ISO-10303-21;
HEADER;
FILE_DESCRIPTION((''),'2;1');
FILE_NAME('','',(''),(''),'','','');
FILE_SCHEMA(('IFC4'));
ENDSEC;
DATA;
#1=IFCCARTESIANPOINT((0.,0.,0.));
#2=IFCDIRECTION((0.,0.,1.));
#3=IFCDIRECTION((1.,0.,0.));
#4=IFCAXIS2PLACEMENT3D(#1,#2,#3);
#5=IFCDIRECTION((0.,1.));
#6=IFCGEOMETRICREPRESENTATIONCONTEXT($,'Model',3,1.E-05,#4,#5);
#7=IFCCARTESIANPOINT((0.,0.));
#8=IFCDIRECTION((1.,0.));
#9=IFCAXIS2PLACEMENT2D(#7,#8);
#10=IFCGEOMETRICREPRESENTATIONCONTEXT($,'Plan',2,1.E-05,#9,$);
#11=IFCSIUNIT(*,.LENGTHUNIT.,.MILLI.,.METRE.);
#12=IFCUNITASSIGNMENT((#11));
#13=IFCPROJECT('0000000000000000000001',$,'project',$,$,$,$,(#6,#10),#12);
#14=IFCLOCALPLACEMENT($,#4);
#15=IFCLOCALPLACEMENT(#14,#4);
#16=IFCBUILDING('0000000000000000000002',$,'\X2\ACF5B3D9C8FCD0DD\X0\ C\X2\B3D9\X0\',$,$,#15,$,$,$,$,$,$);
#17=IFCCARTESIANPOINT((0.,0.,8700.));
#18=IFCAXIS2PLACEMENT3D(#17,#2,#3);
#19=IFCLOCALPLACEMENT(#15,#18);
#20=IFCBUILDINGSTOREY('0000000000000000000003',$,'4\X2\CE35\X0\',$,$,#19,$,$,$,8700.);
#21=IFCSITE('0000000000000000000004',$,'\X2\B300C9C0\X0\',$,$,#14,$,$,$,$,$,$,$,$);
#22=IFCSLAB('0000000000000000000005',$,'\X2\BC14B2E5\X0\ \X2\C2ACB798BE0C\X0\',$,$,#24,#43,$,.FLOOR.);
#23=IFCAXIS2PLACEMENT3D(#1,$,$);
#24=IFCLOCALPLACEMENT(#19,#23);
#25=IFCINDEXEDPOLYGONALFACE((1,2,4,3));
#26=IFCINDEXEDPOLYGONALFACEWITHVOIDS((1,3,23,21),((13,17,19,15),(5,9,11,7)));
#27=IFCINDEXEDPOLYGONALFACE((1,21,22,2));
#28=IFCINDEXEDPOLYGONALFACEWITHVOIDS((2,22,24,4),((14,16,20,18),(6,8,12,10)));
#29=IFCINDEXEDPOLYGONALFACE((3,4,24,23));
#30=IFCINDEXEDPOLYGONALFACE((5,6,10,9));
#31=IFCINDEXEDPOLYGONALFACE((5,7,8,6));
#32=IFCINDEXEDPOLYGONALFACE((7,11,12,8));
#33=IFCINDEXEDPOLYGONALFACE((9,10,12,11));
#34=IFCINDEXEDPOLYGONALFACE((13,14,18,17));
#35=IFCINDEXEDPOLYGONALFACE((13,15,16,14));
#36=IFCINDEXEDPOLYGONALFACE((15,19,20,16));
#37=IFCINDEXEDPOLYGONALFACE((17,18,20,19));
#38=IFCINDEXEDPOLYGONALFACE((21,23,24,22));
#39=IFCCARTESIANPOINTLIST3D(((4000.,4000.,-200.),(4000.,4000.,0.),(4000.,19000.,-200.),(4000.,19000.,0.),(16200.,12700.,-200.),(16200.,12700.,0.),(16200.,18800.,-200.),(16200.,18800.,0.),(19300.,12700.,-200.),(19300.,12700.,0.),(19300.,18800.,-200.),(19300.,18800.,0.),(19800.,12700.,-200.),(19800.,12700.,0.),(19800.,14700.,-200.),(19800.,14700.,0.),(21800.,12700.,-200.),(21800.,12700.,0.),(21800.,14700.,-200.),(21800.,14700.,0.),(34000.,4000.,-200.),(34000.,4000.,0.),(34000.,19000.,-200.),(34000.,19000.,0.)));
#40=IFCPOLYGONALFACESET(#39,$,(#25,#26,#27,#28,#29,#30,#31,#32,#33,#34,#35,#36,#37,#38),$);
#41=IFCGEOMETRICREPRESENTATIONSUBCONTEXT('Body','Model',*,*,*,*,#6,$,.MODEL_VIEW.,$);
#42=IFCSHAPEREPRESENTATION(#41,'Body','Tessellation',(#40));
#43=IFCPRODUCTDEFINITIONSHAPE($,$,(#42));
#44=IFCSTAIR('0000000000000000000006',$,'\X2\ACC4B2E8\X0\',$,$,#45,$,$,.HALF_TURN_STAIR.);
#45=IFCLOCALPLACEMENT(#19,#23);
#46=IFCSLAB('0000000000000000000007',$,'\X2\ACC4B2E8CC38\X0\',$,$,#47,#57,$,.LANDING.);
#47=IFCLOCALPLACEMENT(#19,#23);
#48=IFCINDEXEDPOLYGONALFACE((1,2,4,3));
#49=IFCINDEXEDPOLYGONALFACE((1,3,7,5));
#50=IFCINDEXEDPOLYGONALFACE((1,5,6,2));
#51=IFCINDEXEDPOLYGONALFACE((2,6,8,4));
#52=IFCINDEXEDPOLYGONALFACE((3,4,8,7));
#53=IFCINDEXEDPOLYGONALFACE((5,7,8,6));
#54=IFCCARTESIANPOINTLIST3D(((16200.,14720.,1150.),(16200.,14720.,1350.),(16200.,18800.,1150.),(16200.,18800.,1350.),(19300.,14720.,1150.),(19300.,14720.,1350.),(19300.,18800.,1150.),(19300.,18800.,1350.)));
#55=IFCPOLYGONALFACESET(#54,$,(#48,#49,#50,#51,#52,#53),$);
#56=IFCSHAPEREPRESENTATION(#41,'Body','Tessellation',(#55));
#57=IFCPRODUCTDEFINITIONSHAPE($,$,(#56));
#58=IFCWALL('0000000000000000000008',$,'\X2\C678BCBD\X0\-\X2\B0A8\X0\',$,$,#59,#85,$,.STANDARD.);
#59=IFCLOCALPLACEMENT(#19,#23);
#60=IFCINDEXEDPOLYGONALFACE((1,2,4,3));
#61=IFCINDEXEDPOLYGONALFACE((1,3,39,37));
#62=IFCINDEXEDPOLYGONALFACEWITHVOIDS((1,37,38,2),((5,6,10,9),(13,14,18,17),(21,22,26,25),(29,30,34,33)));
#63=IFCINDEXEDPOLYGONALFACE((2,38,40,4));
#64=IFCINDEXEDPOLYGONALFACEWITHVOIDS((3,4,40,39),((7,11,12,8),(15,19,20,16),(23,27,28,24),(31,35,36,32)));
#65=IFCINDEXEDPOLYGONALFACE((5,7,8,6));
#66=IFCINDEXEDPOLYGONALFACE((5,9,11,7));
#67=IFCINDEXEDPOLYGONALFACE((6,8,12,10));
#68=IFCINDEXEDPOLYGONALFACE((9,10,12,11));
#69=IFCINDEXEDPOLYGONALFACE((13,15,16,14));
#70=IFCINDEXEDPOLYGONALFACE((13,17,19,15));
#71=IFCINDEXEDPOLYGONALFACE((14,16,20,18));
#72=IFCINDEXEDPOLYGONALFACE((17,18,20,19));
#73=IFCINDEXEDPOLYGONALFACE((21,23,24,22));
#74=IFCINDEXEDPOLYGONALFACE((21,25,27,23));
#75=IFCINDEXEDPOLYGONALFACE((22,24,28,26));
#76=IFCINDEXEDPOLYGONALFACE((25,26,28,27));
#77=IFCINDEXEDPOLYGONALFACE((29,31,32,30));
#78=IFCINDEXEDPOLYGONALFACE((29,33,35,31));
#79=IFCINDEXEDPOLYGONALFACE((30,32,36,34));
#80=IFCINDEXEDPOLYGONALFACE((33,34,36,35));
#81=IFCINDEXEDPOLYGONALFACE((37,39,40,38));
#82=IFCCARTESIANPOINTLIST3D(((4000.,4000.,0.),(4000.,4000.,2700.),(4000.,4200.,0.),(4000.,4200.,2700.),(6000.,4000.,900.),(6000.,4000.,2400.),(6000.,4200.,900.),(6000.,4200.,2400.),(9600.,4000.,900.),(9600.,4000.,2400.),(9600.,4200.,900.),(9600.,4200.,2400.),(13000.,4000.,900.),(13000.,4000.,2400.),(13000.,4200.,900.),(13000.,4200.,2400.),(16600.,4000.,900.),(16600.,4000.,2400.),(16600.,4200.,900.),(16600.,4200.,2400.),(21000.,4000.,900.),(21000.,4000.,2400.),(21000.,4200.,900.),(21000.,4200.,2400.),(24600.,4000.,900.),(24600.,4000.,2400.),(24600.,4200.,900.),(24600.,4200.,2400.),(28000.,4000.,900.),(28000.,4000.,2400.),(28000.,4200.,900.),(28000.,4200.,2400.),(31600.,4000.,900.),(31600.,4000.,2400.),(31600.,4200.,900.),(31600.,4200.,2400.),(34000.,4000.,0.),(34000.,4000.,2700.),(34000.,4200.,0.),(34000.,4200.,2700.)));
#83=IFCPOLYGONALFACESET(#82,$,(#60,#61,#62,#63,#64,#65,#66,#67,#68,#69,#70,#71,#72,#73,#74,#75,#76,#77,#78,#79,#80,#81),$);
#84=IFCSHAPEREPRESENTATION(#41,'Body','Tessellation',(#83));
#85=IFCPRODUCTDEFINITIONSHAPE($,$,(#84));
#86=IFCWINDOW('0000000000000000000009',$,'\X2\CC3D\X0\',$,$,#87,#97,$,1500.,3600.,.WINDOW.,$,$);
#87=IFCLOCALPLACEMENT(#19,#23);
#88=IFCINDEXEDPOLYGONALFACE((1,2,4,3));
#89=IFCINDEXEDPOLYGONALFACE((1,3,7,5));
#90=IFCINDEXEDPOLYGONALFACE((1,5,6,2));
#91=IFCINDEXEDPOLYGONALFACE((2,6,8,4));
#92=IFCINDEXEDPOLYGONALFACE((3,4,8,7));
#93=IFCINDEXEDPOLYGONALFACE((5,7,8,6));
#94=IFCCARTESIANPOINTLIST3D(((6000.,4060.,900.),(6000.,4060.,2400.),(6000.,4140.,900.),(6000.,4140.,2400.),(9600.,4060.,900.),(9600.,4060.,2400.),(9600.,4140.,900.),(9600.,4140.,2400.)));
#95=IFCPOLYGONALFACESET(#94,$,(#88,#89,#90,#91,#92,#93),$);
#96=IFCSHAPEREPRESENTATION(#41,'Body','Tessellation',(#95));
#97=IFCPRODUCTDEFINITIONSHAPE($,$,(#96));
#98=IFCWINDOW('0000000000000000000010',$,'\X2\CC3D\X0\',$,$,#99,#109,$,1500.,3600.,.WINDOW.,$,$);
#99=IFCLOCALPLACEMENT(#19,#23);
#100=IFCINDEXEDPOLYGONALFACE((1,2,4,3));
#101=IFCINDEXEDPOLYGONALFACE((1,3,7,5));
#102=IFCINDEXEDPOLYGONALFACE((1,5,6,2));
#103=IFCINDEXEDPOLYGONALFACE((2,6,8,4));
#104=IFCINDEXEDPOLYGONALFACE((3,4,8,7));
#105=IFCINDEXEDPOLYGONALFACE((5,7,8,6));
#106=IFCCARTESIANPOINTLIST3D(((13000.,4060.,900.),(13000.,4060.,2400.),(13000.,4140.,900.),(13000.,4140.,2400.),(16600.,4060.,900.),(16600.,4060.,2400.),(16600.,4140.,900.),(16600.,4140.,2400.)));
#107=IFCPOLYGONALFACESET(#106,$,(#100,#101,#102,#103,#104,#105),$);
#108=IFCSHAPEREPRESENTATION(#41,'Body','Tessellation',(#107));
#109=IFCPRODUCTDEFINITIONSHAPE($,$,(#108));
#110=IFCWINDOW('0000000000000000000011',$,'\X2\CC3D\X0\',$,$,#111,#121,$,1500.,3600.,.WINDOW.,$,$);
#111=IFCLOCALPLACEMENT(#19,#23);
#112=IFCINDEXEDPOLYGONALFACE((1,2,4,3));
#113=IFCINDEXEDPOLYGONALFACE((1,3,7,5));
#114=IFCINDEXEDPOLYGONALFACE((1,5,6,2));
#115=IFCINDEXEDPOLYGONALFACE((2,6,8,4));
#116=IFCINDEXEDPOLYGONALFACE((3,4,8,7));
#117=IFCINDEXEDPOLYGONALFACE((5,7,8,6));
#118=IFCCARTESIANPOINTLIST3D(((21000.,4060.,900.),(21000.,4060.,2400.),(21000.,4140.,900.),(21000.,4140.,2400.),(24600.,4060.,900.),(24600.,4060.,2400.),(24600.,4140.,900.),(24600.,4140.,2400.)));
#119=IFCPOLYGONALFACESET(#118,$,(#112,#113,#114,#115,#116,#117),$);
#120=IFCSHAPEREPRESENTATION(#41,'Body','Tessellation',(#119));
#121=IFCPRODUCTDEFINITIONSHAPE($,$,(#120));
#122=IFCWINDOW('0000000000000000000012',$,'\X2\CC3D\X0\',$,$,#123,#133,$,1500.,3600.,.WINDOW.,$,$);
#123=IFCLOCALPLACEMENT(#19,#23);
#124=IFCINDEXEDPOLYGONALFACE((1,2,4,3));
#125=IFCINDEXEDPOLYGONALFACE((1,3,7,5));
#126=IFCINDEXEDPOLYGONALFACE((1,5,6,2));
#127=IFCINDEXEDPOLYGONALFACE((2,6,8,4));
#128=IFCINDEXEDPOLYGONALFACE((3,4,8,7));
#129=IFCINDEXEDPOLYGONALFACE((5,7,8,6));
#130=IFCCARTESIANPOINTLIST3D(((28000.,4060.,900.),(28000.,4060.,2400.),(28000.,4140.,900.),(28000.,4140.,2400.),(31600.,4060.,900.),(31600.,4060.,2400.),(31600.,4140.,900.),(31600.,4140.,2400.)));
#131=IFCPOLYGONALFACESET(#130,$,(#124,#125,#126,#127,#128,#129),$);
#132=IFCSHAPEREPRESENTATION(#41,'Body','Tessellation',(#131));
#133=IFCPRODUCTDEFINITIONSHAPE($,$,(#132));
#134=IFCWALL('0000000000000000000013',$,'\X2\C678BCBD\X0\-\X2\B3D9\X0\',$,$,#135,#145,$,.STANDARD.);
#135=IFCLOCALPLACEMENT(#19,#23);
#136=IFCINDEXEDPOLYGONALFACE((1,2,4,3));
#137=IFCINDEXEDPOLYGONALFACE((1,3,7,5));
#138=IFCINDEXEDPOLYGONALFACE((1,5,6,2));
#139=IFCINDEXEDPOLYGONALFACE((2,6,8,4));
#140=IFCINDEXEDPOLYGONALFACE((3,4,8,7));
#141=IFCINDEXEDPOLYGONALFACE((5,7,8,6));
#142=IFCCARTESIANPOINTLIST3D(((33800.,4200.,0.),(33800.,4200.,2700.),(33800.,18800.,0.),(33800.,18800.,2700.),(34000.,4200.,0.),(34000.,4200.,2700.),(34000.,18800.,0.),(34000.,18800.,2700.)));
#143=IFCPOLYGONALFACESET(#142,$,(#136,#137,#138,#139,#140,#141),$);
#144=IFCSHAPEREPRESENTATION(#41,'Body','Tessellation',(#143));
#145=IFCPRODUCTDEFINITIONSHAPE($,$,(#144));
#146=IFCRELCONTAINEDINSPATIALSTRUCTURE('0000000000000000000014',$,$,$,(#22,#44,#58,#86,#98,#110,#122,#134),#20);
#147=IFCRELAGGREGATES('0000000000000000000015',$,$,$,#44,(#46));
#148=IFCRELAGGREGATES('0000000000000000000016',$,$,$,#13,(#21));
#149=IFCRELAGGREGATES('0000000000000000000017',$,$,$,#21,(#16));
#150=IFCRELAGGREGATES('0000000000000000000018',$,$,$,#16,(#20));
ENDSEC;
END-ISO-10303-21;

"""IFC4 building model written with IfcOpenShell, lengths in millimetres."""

from ifc_helpers import new_model, si_unit, direction, frame, origin_with_axes, origin_2d_with_axis, place, context, subcontext, project, spatial, polyline, outline, extrude, element, fill, aggregate, save


model = new_model("IFC4")

# Units and contexts
model_context = context("Model", 3, precision=1e-05, world=origin_with_axes(), true_north=direction((0.0, 1.0)))
plan_context = context("Plan", 2, precision=1e-05, world=origin_2d_with_axis())
body_context = subcontext(model_context, "Body", "Model", "MODEL_VIEW")
ifc_project = project(units=[si_unit("LENGTHUNIT", "METRE", prefix="MILLI")], contexts=[model_context, plan_context])

# Site, building, storey
site_placement = place(None, origin_with_axes())
site = spatial("IfcSite", under=ifc_project, at=site_placement, Name="대지")
building_placement = place(site_placement, origin_with_axes())
building = spatial("IfcBuilding", under=site, at=building_placement, Name="공동주택 C동")
storey_placement = place(building_placement, frame((0.0, 0.0, 8700.0), z_axis=(0.0, 0.0, 1.0), x_axis=(1.0, 0.0, 0.0)))
storey = spatial("IfcBuildingStorey", under=building, at=storey_placement, Name="4층", Elevation=8700.0)

# Slab
slab_1_placement = place(storey_placement, origin_with_axes())
element("IfcSlab", 1, at=slab_1_placement, inside=storey, Name="바닥 슬래브", PredefinedType="FLOOR", context=body_context, shape_type="SweptSolid", body=[
    extrude(outline(polyline([(4000.0, 4000.0), (34000.0, 4000.0), (34000.0, 19000.0), (4000.0, 19000.0), (4000.0, 4000.0)]), holes=[polyline([(16200.0, 12700.0), (19300.0, 12700.0), (19300.0, 18800.0), (16200.0, 18800.0), (16200.0, 12700.0)]), polyline([(19800.0, 12700.0), (21800.0, 12700.0), (21800.0, 14700.0), (19800.0, 14700.0), (19800.0, 12700.0)])]), frame((0.0, 0.0, -200.0), z_axis=(0.0, 0.0, 1.0), x_axis=(1.0, 0.0, 0.0)), (0.0, 0.0, 1.0), 200.0),
])

# Stair, slab
stair_placement = place(storey_placement, origin_with_axes())
stair = element("IfcStair", 2, at=stair_placement, inside=storey, Name="계단", PredefinedType="HALF_TURN_STAIR")
slab_2_placement = place(stair_placement, origin_with_axes())
slab_2 = element("IfcSlab", 3, at=slab_2_placement, Name="계단참", PredefinedType="LANDING", context=body_context, shape_type="SweptSolid", body=[
    extrude(outline(polyline([(16200.0, 14720.0), (19300.0, 14720.0), (19300.0, 18800.0), (16200.0, 18800.0), (16200.0, 14720.0)])), frame((0.0, 0.0, 1150.0), z_axis=(0.0, 0.0, 1.0), x_axis=(1.0, 0.0, 0.0)), (0.0, 0.0, 1.0), 200.0),
])

# Wall, openings, windows
wall_1_placement = place(storey_placement, origin_with_axes())
wall_1 = element("IfcWall", 4, at=wall_1_placement, inside=storey, Name="외벽-남", PredefinedType="STANDARD", context=body_context, shape_type="SweptSolid", body=[
    extrude(outline(polyline([(4000.0, 4200.0), (34000.0, 4200.0), (34000.0, 4000.0), (4000.0, 4000.0), (4000.0, 4200.0)])), origin_with_axes(), (0.0, 0.0, 1.0), 2700.0),
])
opening_1_placement = place(storey_placement, origin_with_axes())
opening_1 = element("IfcOpeningElement", 5, at=opening_1_placement, cuts=wall_1, PredefinedType="OPENING", context=body_context, shape_type="SweptSolid", body=[
    extrude(outline(polyline([(6000.0, 3950.0), (9600.0, 3950.0), (9600.0, 4250.0), (6000.0, 4250.0), (6000.0, 3950.0)])), frame((0.0, 0.0, 900.0), z_axis=(0.0, 0.0, 1.0), x_axis=(1.0, 0.0, 0.0)), (0.0, 0.0, 1.0), 1500.0),
])
opening_2_placement = place(storey_placement, origin_with_axes())
opening_2 = element("IfcOpeningElement", 6, at=opening_2_placement, cuts=wall_1, PredefinedType="OPENING", context=body_context, shape_type="SweptSolid", body=[
    extrude(outline(polyline([(13000.0, 3950.0), (16600.0, 3950.0), (16600.0, 4250.0), (13000.0, 4250.0), (13000.0, 3950.0)])), frame((0.0, 0.0, 900.0), z_axis=(0.0, 0.0, 1.0), x_axis=(1.0, 0.0, 0.0)), (0.0, 0.0, 1.0), 1500.0),
])
opening_3_placement = place(storey_placement, origin_with_axes())
opening_3 = element("IfcOpeningElement", 7, at=opening_3_placement, cuts=wall_1, PredefinedType="OPENING", context=body_context, shape_type="SweptSolid", body=[
    extrude(outline(polyline([(21000.0, 3950.0), (24600.0, 3950.0), (24600.0, 4250.0), (21000.0, 4250.0), (21000.0, 3950.0)])), frame((0.0, 0.0, 900.0), z_axis=(0.0, 0.0, 1.0), x_axis=(1.0, 0.0, 0.0)), (0.0, 0.0, 1.0), 1500.0),
])
opening_4_placement = place(storey_placement, origin_with_axes())
opening_4 = element("IfcOpeningElement", 8, at=opening_4_placement, cuts=wall_1, PredefinedType="OPENING", context=body_context, shape_type="SweptSolid", body=[
    extrude(outline(polyline([(28000.0, 3950.0), (31600.0, 3950.0), (31600.0, 4250.0), (28000.0, 4250.0), (28000.0, 3950.0)])), frame((0.0, 0.0, 900.0), z_axis=(0.0, 0.0, 1.0), x_axis=(1.0, 0.0, 0.0)), (0.0, 0.0, 1.0), 1500.0),
])
window_1_placement = place(storey_placement, origin_with_axes())
window_1 = element("IfcWindow", 9, at=window_1_placement, inside=storey, Name="창", OverallHeight=1500.0, OverallWidth=3600.0, PredefinedType="WINDOW", context=body_context, shape_type="SweptSolid", body=[
    extrude(outline(polyline([(6000.0, 4060.0), (9600.0, 4060.0), (9600.0, 4140.0), (6000.0, 4140.0), (6000.0, 4060.0)])), frame((0.0, 0.0, 900.0), z_axis=(0.0, 0.0, 1.0), x_axis=(1.0, 0.0, 0.0)), (0.0, 0.0, 1.0), 1500.0),
])
fill(opening_1, window_1)
window_2_placement = place(storey_placement, origin_with_axes())
window_2 = element("IfcWindow", 10, at=window_2_placement, inside=storey, Name="창", OverallHeight=1500.0, OverallWidth=3600.0, PredefinedType="WINDOW", context=body_context, shape_type="SweptSolid", body=[
    extrude(outline(polyline([(13000.0, 4060.0), (16600.0, 4060.0), (16600.0, 4140.0), (13000.0, 4140.0), (13000.0, 4060.0)])), frame((0.0, 0.0, 900.0), z_axis=(0.0, 0.0, 1.0), x_axis=(1.0, 0.0, 0.0)), (0.0, 0.0, 1.0), 1500.0),
])
fill(opening_2, window_2)
window_3_placement = place(storey_placement, origin_with_axes())
window_3 = element("IfcWindow", 11, at=window_3_placement, inside=storey, Name="창", OverallHeight=1500.0, OverallWidth=3600.0, PredefinedType="WINDOW", context=body_context, shape_type="SweptSolid", body=[
    extrude(outline(polyline([(21000.0, 4060.0), (24600.0, 4060.0), (24600.0, 4140.0), (21000.0, 4140.0), (21000.0, 4060.0)])), frame((0.0, 0.0, 900.0), z_axis=(0.0, 0.0, 1.0), x_axis=(1.0, 0.0, 0.0)), (0.0, 0.0, 1.0), 1500.0),
])
fill(opening_3, window_3)
window_4_placement = place(storey_placement, origin_with_axes())
window_4 = element("IfcWindow", 12, at=window_4_placement, inside=storey, Name="창", OverallHeight=1500.0, OverallWidth=3600.0, PredefinedType="WINDOW", context=body_context, shape_type="SweptSolid", body=[
    extrude(outline(polyline([(28000.0, 4060.0), (31600.0, 4060.0), (31600.0, 4140.0), (28000.0, 4140.0), (28000.0, 4060.0)])), frame((0.0, 0.0, 900.0), z_axis=(0.0, 0.0, 1.0), x_axis=(1.0, 0.0, 0.0)), (0.0, 0.0, 1.0), 1500.0),
])
fill(opening_4, window_4)

# Wall
wall_2_placement = place(storey_placement, origin_with_axes())
element("IfcWall", 13, at=wall_2_placement, inside=storey, Name="외벽-동", PredefinedType="STANDARD", context=body_context, shape_type="SweptSolid", body=[
    extrude(outline(polyline([(33800.0, 4200.0), (33800.0, 18800.0), (34000.0, 18800.0), (34000.0, 4200.0), (33800.0, 4200.0)])), origin_with_axes(), (0.0, 0.0, 1.0), 2700.0),
])

aggregate(stair, [slab_2])

save(model, "model.ifc")
